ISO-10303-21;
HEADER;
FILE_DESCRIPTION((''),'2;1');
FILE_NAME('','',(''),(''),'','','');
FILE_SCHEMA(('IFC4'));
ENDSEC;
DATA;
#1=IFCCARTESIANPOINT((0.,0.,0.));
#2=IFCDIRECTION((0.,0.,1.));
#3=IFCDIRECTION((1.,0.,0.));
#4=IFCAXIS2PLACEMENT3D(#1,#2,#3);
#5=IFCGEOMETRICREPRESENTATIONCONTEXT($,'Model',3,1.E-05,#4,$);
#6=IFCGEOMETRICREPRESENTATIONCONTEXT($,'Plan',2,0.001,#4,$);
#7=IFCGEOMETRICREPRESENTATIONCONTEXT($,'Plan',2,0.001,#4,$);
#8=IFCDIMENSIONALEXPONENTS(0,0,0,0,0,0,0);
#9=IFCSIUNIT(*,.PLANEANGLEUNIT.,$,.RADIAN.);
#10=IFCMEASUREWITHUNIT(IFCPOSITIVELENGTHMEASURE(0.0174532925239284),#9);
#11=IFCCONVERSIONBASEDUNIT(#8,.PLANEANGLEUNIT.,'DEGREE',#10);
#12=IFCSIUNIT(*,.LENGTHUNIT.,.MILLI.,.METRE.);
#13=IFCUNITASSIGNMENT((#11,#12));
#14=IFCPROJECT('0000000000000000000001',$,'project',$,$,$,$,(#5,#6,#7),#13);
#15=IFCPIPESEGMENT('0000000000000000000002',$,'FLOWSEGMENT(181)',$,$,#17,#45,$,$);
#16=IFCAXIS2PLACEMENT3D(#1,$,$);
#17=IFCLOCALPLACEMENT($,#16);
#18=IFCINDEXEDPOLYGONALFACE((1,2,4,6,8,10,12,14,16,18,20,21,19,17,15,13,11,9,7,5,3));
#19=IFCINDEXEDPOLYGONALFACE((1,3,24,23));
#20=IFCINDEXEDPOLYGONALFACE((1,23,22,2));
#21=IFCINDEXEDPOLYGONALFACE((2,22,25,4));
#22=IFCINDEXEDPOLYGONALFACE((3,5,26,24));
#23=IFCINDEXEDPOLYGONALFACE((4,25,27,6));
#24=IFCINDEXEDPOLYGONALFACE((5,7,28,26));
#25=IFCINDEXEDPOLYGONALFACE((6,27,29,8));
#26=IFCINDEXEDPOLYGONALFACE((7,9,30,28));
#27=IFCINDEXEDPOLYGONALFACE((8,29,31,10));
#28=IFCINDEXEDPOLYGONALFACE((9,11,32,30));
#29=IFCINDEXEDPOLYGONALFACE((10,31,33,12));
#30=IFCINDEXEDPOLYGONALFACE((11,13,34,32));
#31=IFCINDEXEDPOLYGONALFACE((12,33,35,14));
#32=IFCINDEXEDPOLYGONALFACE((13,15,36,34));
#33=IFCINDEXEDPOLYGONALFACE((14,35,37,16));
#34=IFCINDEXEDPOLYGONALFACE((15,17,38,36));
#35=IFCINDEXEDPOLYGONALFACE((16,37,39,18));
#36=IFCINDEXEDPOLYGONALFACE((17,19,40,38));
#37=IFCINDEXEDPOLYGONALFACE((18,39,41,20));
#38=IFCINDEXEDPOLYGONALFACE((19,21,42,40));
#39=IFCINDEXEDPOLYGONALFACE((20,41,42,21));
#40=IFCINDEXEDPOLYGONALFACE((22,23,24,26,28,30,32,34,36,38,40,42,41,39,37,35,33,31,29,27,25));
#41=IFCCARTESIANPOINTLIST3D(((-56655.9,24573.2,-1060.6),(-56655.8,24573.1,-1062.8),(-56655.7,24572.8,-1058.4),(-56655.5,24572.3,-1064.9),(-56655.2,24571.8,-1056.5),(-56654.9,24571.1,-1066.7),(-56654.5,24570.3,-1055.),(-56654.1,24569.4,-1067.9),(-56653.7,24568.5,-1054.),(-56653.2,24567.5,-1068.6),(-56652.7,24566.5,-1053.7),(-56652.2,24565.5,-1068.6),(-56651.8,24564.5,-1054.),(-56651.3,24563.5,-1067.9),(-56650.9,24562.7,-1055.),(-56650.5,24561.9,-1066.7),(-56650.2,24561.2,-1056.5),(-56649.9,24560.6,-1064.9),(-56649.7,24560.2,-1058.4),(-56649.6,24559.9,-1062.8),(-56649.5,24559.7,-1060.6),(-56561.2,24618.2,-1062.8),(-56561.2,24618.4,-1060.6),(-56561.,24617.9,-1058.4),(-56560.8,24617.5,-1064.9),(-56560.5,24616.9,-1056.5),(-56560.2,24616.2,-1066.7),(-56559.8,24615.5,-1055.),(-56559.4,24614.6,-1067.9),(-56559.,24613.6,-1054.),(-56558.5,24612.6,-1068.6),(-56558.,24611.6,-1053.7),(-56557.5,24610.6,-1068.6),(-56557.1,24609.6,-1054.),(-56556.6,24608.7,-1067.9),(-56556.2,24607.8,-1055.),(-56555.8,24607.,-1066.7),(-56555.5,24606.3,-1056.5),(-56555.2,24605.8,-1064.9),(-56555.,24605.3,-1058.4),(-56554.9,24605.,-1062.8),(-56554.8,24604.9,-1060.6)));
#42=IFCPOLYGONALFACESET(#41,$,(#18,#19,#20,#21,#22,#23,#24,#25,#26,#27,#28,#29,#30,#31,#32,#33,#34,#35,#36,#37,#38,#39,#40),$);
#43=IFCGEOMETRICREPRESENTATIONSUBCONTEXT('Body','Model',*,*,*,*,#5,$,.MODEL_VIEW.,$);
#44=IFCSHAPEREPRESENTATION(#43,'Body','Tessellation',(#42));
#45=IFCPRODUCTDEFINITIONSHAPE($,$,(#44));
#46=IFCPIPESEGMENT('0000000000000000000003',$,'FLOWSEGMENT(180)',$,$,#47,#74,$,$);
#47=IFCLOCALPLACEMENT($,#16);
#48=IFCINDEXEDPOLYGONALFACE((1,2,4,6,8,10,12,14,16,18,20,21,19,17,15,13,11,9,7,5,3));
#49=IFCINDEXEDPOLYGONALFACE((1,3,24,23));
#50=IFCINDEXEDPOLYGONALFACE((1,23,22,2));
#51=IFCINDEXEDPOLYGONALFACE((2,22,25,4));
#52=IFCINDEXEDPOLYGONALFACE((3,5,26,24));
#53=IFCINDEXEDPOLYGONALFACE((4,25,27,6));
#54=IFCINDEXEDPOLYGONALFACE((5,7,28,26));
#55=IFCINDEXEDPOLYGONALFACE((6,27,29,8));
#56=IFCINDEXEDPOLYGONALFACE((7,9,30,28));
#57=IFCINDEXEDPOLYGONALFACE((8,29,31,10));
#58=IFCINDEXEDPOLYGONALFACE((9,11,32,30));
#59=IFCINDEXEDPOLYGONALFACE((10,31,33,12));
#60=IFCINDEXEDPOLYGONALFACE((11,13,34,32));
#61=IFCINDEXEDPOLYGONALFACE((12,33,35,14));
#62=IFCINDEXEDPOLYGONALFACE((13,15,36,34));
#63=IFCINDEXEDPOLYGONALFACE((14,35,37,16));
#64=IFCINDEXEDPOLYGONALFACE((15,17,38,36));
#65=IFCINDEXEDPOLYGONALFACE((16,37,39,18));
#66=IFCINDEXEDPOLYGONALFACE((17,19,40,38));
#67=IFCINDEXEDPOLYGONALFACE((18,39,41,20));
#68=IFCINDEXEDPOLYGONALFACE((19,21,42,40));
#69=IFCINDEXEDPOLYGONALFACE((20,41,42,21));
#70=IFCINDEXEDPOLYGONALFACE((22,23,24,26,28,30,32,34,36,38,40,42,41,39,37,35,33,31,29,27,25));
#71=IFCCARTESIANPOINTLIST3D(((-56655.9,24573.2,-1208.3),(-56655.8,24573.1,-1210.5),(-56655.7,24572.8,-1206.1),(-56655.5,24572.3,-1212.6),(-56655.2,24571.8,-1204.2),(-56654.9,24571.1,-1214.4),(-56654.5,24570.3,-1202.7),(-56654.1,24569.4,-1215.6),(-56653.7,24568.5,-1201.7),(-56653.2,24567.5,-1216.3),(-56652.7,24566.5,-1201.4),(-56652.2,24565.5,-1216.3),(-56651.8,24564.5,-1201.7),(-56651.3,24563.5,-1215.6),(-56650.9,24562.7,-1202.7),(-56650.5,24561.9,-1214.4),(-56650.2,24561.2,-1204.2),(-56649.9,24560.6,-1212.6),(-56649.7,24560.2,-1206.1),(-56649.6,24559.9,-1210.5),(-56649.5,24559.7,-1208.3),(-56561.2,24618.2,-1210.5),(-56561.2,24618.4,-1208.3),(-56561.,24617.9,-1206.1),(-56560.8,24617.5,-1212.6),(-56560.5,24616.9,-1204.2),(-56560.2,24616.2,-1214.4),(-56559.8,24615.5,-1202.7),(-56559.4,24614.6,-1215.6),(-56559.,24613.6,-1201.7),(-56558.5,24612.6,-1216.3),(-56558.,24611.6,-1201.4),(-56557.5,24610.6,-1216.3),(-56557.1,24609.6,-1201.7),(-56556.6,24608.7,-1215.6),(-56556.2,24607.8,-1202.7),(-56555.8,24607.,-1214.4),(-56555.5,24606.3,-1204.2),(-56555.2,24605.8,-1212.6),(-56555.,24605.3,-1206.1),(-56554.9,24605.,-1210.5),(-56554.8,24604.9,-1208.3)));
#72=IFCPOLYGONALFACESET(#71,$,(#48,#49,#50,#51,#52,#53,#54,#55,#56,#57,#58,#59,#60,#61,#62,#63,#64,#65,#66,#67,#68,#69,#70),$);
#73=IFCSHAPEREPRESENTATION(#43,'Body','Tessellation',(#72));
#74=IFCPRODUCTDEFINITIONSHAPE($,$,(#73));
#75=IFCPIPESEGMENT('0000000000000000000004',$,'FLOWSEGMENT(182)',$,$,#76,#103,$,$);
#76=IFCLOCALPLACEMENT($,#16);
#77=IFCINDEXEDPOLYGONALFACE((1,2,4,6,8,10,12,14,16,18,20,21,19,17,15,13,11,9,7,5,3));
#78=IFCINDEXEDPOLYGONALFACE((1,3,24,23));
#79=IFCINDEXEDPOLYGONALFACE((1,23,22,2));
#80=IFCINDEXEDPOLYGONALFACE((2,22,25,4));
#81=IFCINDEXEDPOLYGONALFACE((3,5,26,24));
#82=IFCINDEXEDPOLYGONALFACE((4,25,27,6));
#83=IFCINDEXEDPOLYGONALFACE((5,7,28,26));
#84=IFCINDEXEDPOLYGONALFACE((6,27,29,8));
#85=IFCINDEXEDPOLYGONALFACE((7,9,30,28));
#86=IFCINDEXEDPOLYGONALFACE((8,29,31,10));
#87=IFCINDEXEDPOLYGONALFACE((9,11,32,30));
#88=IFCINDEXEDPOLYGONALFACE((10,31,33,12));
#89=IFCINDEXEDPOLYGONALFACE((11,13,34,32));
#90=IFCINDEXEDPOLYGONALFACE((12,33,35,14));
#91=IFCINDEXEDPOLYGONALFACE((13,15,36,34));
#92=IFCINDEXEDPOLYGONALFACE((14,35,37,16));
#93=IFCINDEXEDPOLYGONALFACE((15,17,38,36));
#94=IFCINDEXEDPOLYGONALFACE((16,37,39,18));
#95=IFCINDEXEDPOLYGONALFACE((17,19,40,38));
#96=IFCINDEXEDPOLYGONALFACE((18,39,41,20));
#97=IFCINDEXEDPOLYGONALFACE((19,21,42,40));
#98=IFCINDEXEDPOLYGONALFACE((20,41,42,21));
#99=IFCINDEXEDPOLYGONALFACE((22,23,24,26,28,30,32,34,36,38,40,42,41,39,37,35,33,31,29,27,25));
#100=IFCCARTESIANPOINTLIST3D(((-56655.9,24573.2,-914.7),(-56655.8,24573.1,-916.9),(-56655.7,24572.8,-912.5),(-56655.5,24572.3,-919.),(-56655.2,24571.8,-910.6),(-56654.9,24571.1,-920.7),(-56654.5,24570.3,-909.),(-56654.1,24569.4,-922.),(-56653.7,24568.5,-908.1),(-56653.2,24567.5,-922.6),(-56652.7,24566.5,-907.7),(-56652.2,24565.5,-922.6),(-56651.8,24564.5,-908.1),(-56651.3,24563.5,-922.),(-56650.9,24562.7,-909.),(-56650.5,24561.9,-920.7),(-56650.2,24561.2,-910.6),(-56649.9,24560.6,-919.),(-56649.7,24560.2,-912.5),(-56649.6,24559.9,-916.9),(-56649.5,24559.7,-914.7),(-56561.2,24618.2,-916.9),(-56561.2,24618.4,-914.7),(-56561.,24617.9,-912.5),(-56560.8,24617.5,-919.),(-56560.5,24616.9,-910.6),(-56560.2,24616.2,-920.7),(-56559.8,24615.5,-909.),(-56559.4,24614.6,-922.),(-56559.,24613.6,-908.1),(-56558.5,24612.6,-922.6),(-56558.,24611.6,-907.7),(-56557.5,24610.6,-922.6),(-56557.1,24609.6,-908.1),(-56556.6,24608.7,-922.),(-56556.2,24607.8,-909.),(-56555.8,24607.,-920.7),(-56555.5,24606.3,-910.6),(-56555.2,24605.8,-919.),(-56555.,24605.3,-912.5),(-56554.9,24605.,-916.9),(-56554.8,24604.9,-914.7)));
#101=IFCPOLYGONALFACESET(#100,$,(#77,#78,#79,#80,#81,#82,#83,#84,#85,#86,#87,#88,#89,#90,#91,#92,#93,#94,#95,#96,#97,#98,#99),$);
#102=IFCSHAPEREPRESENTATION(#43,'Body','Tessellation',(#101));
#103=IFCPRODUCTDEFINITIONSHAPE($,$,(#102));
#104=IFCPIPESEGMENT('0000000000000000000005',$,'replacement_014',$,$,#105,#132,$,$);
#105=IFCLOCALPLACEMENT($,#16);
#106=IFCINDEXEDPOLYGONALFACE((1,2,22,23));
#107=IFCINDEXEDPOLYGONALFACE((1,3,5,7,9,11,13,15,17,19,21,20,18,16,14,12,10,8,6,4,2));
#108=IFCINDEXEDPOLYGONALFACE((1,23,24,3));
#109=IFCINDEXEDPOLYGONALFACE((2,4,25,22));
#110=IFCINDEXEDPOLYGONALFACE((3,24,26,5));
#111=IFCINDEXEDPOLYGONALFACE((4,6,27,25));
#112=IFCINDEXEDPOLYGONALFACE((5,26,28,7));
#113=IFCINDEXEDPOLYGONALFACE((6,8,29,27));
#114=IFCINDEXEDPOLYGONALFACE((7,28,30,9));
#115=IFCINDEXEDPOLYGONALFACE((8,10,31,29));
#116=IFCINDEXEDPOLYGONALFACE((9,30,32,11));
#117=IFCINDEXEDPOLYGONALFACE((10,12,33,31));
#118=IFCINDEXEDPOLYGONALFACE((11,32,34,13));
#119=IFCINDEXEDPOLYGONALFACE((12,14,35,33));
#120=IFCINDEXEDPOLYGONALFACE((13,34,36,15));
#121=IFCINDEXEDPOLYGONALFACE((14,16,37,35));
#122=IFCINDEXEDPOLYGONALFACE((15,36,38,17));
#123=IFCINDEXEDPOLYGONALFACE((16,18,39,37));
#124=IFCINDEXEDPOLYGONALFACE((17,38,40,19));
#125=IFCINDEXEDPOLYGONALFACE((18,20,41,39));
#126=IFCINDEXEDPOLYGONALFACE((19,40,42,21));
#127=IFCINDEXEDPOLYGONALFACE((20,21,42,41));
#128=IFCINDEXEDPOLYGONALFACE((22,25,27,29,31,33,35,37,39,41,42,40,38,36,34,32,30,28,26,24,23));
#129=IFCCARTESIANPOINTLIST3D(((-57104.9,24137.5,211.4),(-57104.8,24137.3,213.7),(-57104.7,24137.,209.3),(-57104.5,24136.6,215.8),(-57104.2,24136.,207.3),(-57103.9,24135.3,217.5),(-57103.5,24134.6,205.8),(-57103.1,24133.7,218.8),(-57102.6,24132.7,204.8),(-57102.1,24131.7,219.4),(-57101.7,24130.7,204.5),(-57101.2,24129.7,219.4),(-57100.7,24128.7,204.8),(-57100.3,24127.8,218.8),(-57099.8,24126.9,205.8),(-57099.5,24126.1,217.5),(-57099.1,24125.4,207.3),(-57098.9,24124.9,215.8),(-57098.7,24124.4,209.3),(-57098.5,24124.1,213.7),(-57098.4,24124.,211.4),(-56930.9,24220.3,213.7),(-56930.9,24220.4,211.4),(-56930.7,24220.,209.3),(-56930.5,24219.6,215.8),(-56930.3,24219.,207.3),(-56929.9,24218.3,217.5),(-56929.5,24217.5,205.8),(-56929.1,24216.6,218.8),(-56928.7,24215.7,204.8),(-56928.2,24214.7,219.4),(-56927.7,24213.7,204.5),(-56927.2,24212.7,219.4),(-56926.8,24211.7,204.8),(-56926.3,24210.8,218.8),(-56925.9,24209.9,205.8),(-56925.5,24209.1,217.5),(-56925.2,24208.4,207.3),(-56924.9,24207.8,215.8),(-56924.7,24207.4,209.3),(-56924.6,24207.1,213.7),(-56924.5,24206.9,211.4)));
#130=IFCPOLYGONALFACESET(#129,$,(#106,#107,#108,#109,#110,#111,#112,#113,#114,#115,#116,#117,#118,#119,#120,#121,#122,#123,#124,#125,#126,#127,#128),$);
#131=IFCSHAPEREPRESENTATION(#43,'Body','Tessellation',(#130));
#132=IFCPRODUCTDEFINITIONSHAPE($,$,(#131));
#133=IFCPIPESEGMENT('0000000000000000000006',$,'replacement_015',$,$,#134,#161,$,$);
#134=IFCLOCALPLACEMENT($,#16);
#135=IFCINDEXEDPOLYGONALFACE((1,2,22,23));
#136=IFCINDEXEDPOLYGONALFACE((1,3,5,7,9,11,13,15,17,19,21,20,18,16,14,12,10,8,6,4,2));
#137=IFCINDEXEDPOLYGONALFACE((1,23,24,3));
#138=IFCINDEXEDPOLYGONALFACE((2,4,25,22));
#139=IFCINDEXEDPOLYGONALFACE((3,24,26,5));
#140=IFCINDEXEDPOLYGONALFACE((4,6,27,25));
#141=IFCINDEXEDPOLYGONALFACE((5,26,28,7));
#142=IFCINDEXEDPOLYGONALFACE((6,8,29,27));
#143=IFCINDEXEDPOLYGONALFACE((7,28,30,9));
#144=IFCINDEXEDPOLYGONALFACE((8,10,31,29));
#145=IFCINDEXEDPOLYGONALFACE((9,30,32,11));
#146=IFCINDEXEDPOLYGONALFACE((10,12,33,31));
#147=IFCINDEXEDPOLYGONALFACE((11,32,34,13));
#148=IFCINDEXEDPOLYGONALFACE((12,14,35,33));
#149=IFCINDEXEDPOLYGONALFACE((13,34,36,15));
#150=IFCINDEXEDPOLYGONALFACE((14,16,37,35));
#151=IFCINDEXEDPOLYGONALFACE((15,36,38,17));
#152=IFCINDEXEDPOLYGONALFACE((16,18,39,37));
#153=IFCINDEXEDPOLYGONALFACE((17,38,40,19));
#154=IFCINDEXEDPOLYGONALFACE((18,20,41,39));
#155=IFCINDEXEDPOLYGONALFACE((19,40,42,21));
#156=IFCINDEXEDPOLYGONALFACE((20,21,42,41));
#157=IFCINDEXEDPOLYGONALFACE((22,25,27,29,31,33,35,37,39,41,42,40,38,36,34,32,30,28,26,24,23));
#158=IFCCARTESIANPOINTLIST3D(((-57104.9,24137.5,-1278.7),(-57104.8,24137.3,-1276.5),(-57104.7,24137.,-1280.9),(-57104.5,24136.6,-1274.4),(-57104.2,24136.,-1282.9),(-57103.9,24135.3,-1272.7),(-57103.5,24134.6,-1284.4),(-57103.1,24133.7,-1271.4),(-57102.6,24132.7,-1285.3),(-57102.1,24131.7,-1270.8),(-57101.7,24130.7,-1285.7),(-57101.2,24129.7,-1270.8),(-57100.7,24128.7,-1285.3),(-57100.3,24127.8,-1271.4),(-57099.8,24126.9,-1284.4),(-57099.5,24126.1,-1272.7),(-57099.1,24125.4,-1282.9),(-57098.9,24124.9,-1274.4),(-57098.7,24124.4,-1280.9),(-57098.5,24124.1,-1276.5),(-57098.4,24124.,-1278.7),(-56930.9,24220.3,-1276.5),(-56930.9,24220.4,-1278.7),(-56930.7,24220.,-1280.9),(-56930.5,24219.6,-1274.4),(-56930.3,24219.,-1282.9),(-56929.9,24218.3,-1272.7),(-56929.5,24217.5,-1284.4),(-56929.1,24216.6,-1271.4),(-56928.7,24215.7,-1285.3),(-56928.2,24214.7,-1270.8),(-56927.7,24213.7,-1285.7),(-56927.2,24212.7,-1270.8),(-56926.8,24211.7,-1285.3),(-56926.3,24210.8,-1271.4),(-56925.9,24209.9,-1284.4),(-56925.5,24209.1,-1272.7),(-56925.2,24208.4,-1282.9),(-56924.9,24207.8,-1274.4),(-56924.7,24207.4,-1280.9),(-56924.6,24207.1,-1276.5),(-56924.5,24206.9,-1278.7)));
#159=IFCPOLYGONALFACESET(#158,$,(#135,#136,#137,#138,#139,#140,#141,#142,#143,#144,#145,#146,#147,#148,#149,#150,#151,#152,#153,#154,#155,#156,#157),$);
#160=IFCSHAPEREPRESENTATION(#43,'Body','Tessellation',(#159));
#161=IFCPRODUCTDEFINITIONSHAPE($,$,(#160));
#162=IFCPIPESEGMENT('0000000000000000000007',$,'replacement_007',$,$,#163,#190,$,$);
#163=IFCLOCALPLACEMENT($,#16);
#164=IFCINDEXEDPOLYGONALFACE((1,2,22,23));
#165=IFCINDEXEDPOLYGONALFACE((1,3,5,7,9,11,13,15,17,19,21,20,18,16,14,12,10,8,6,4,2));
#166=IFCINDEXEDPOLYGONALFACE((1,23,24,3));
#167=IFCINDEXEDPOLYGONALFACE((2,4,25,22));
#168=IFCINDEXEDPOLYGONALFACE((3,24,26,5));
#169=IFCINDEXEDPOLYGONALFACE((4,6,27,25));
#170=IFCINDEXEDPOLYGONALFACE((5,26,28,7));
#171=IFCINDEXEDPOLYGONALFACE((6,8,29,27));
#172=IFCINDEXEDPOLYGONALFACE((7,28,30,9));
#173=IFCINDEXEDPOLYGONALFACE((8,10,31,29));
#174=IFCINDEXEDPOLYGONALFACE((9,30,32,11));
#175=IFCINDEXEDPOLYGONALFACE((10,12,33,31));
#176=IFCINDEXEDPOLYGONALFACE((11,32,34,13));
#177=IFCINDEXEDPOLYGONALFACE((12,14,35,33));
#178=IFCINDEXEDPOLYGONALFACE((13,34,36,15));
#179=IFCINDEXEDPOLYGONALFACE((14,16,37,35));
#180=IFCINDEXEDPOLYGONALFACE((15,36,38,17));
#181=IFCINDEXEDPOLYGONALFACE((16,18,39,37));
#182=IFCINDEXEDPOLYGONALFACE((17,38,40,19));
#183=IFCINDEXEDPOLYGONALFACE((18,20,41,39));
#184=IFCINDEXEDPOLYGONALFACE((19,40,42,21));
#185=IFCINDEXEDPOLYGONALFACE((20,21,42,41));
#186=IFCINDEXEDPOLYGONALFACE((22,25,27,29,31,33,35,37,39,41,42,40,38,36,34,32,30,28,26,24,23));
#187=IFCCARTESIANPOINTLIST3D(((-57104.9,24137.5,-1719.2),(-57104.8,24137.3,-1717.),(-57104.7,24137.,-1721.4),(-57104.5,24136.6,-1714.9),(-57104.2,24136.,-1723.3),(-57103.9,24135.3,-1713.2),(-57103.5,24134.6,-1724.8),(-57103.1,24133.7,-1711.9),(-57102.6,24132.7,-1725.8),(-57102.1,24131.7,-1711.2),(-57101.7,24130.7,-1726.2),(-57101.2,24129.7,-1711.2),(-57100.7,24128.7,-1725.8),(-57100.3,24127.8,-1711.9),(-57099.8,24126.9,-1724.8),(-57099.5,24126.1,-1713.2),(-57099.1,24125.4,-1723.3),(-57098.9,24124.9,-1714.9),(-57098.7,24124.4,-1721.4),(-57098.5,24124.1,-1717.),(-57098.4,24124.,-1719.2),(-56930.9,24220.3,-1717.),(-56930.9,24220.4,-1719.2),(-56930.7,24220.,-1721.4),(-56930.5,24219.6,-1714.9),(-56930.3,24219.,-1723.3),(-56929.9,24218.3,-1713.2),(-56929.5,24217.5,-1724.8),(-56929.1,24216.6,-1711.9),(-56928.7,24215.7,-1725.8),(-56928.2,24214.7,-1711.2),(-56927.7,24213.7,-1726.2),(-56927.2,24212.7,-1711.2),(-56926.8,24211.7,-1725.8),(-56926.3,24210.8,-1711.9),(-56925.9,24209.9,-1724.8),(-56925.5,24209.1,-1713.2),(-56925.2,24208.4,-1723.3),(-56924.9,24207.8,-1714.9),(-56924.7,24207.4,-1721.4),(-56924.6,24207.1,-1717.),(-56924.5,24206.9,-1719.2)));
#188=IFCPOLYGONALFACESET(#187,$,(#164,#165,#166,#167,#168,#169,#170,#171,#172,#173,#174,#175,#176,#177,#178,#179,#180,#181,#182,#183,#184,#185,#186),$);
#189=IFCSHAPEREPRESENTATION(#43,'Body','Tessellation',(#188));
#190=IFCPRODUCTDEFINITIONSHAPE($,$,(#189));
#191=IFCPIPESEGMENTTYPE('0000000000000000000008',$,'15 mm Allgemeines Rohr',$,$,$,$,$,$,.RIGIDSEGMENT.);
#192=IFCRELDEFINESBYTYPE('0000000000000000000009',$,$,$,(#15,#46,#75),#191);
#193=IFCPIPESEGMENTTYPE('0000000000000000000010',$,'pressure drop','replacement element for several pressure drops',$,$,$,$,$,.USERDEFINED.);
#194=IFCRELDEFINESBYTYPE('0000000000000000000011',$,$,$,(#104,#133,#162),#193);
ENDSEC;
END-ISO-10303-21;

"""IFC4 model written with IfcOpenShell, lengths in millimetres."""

from ifc_helpers import new_model, entity, si_unit, converted_unit, frame, frame_2d, origin, origin_with_axes, place, context, subcontext, project, circle, extrude, source, transform, mapped, type_object, element, save


model = new_model("IFC4")

# Units and contexts
model_context = context("Model", 3, precision=1e-05, world=origin_with_axes())
plan_context_1 = context("Plan", 2, precision=0.001, world=origin_with_axes())
plan_context_2 = context("Plan", 2, precision=0.001, world=origin_with_axes())
body_context = subcontext(model_context, "Body", "Model", "MODEL_VIEW")
ifc_project = project(units=[converted_unit("PLANEANGLEUNIT", "DEGREE", entity("IfcPositiveLengthMeasure", 0.0174532925239284), si_unit("PLANEANGLEUNIT", "RADIAN"), dimensions=[0, 0, 0, 0, 0, 0, 0]), si_unit("LENGTHUNIT", "METRE", prefix="MILLI")], contexts=[model_context, plan_context_1, plan_context_2])

# Pipe segments
pipe_segment_type_1 = type_object("IfcPipeSegmentType", Name="15 mm Allgemeines Rohr", PredefinedType="RIGIDSEGMENT")
shared_shape = source(origin(), body_context, "Body", "SweptSolid", [
    extrude(circle(Radius=7.5, at=frame_2d((7.5, 7.5), x_axis=(1.0, 0.0))), frame((0.0, -7.5, -7.5), z_axis=(1.0, 0.0, 0.0), x_axis=(0.0, 1.0, 0.0)), (0.0, 0.0, 1.0), 1.0),
])
placement_1 = place(None, origin_with_axes())
placement_2 = place(placement_1, origin_with_axes())
placement_3 = place(placement_2, frame((0.0, 0.0, -3400.0), z_axis=(0.0, 0.0, 1.0), x_axis=(1.0, 0.0, 0.0)))
for number, where, z_axis, x_axis, name in (
    (1, (-56558.0, 24611.6, 2338.8), (-0.430461, 0.902609, 0.0), (-0.902609, -0.430461, 0.0), "FLOWSEGMENT(181)"),
    (2, (-56558.0, 24611.6, 2191.1), (-0.430461, 0.902609, 0.0), (-0.902609, -0.430461, 0.0), "FLOWSEGMENT(180)"),
    (3, (-56558.0, 24611.6, 2484.8), (-0.430461, 0.902609, 0.0), (-0.902609, -0.430461, 0.0), "FLOWSEGMENT(182)"),
):
    element("IfcPipeSegment", number, at=place(placement_3, frame(where, z_axis=z_axis, x_axis=x_axis)), type_object=pipe_segment_type_1, Name=name, context=body_context, shape_type="MappedRepresentation", body=[
        mapped(shared_shape, transform((0.0, 0.0, 0.0), x_axis=(1.0, 0.0, 0.0), y_axis=(0.0, 1.0, 0.0), z_axis=(0.0, 0.0, 1.0), scale=104.898581, scale2=1.0, scale3=1.0, uniform=False)),
    ])
pipe_segment_type_2 = type_object("IfcPipeSegmentType", Name="pressure drop", Description="replacement element for several pressure drops", PredefinedType="USERDEFINED")
pipe_segment_1_placement = place(placement_3, frame((-57101.7, 24130.7, 3612.0), z_axis=(-0.430461, 0.902609, 0.0), x_axis=(0.902609, 0.430461, 0.0)))
element("IfcPipeSegment", 4, at=pipe_segment_1_placement, type_object=pipe_segment_type_2, Name="replacement_014", context=body_context, shape_type="MappedRepresentation", body=[
    mapped(shared_shape, transform((0.0, 0.0, 0.0), x_axis=(1.0, 0.0, 0.0), y_axis=(0.0, 1.0, 0.0), z_axis=(0.0, 0.0, 1.0), scale=192.697716, scale2=1.0, scale3=1.0, uniform=False)),
])
for number, where, z_axis, x_axis, name in (
    (5, (-57101.7, 24130.7, 2121.8), (-0.430461, 0.902609, 0.0), (0.902609, 0.430461, 0.0), "replacement_015"),
    (6, (-57101.7, 24130.7, 1681.3), (-0.430461, 0.902609, 0.0), (0.902609, 0.430461, 0.0), "replacement_007"),
):
    element("IfcPipeSegment", number, at=place(placement_3, frame(where, z_axis=z_axis, x_axis=x_axis)), type_object=pipe_segment_type_2, Name=name, context=body_context, shape_type="MappedRepresentation", body=[
        mapped(shared_shape, transform((0.0, 0.0, 0.0), x_axis=(1.0, 0.0, 0.0), y_axis=(0.0, 1.0, 0.0), z_axis=(0.0, 0.0, 1.0), scale=192.697716, scale2=1.0, scale3=1.0, uniform=False)),
    ])

save(model, "model.ifc")
